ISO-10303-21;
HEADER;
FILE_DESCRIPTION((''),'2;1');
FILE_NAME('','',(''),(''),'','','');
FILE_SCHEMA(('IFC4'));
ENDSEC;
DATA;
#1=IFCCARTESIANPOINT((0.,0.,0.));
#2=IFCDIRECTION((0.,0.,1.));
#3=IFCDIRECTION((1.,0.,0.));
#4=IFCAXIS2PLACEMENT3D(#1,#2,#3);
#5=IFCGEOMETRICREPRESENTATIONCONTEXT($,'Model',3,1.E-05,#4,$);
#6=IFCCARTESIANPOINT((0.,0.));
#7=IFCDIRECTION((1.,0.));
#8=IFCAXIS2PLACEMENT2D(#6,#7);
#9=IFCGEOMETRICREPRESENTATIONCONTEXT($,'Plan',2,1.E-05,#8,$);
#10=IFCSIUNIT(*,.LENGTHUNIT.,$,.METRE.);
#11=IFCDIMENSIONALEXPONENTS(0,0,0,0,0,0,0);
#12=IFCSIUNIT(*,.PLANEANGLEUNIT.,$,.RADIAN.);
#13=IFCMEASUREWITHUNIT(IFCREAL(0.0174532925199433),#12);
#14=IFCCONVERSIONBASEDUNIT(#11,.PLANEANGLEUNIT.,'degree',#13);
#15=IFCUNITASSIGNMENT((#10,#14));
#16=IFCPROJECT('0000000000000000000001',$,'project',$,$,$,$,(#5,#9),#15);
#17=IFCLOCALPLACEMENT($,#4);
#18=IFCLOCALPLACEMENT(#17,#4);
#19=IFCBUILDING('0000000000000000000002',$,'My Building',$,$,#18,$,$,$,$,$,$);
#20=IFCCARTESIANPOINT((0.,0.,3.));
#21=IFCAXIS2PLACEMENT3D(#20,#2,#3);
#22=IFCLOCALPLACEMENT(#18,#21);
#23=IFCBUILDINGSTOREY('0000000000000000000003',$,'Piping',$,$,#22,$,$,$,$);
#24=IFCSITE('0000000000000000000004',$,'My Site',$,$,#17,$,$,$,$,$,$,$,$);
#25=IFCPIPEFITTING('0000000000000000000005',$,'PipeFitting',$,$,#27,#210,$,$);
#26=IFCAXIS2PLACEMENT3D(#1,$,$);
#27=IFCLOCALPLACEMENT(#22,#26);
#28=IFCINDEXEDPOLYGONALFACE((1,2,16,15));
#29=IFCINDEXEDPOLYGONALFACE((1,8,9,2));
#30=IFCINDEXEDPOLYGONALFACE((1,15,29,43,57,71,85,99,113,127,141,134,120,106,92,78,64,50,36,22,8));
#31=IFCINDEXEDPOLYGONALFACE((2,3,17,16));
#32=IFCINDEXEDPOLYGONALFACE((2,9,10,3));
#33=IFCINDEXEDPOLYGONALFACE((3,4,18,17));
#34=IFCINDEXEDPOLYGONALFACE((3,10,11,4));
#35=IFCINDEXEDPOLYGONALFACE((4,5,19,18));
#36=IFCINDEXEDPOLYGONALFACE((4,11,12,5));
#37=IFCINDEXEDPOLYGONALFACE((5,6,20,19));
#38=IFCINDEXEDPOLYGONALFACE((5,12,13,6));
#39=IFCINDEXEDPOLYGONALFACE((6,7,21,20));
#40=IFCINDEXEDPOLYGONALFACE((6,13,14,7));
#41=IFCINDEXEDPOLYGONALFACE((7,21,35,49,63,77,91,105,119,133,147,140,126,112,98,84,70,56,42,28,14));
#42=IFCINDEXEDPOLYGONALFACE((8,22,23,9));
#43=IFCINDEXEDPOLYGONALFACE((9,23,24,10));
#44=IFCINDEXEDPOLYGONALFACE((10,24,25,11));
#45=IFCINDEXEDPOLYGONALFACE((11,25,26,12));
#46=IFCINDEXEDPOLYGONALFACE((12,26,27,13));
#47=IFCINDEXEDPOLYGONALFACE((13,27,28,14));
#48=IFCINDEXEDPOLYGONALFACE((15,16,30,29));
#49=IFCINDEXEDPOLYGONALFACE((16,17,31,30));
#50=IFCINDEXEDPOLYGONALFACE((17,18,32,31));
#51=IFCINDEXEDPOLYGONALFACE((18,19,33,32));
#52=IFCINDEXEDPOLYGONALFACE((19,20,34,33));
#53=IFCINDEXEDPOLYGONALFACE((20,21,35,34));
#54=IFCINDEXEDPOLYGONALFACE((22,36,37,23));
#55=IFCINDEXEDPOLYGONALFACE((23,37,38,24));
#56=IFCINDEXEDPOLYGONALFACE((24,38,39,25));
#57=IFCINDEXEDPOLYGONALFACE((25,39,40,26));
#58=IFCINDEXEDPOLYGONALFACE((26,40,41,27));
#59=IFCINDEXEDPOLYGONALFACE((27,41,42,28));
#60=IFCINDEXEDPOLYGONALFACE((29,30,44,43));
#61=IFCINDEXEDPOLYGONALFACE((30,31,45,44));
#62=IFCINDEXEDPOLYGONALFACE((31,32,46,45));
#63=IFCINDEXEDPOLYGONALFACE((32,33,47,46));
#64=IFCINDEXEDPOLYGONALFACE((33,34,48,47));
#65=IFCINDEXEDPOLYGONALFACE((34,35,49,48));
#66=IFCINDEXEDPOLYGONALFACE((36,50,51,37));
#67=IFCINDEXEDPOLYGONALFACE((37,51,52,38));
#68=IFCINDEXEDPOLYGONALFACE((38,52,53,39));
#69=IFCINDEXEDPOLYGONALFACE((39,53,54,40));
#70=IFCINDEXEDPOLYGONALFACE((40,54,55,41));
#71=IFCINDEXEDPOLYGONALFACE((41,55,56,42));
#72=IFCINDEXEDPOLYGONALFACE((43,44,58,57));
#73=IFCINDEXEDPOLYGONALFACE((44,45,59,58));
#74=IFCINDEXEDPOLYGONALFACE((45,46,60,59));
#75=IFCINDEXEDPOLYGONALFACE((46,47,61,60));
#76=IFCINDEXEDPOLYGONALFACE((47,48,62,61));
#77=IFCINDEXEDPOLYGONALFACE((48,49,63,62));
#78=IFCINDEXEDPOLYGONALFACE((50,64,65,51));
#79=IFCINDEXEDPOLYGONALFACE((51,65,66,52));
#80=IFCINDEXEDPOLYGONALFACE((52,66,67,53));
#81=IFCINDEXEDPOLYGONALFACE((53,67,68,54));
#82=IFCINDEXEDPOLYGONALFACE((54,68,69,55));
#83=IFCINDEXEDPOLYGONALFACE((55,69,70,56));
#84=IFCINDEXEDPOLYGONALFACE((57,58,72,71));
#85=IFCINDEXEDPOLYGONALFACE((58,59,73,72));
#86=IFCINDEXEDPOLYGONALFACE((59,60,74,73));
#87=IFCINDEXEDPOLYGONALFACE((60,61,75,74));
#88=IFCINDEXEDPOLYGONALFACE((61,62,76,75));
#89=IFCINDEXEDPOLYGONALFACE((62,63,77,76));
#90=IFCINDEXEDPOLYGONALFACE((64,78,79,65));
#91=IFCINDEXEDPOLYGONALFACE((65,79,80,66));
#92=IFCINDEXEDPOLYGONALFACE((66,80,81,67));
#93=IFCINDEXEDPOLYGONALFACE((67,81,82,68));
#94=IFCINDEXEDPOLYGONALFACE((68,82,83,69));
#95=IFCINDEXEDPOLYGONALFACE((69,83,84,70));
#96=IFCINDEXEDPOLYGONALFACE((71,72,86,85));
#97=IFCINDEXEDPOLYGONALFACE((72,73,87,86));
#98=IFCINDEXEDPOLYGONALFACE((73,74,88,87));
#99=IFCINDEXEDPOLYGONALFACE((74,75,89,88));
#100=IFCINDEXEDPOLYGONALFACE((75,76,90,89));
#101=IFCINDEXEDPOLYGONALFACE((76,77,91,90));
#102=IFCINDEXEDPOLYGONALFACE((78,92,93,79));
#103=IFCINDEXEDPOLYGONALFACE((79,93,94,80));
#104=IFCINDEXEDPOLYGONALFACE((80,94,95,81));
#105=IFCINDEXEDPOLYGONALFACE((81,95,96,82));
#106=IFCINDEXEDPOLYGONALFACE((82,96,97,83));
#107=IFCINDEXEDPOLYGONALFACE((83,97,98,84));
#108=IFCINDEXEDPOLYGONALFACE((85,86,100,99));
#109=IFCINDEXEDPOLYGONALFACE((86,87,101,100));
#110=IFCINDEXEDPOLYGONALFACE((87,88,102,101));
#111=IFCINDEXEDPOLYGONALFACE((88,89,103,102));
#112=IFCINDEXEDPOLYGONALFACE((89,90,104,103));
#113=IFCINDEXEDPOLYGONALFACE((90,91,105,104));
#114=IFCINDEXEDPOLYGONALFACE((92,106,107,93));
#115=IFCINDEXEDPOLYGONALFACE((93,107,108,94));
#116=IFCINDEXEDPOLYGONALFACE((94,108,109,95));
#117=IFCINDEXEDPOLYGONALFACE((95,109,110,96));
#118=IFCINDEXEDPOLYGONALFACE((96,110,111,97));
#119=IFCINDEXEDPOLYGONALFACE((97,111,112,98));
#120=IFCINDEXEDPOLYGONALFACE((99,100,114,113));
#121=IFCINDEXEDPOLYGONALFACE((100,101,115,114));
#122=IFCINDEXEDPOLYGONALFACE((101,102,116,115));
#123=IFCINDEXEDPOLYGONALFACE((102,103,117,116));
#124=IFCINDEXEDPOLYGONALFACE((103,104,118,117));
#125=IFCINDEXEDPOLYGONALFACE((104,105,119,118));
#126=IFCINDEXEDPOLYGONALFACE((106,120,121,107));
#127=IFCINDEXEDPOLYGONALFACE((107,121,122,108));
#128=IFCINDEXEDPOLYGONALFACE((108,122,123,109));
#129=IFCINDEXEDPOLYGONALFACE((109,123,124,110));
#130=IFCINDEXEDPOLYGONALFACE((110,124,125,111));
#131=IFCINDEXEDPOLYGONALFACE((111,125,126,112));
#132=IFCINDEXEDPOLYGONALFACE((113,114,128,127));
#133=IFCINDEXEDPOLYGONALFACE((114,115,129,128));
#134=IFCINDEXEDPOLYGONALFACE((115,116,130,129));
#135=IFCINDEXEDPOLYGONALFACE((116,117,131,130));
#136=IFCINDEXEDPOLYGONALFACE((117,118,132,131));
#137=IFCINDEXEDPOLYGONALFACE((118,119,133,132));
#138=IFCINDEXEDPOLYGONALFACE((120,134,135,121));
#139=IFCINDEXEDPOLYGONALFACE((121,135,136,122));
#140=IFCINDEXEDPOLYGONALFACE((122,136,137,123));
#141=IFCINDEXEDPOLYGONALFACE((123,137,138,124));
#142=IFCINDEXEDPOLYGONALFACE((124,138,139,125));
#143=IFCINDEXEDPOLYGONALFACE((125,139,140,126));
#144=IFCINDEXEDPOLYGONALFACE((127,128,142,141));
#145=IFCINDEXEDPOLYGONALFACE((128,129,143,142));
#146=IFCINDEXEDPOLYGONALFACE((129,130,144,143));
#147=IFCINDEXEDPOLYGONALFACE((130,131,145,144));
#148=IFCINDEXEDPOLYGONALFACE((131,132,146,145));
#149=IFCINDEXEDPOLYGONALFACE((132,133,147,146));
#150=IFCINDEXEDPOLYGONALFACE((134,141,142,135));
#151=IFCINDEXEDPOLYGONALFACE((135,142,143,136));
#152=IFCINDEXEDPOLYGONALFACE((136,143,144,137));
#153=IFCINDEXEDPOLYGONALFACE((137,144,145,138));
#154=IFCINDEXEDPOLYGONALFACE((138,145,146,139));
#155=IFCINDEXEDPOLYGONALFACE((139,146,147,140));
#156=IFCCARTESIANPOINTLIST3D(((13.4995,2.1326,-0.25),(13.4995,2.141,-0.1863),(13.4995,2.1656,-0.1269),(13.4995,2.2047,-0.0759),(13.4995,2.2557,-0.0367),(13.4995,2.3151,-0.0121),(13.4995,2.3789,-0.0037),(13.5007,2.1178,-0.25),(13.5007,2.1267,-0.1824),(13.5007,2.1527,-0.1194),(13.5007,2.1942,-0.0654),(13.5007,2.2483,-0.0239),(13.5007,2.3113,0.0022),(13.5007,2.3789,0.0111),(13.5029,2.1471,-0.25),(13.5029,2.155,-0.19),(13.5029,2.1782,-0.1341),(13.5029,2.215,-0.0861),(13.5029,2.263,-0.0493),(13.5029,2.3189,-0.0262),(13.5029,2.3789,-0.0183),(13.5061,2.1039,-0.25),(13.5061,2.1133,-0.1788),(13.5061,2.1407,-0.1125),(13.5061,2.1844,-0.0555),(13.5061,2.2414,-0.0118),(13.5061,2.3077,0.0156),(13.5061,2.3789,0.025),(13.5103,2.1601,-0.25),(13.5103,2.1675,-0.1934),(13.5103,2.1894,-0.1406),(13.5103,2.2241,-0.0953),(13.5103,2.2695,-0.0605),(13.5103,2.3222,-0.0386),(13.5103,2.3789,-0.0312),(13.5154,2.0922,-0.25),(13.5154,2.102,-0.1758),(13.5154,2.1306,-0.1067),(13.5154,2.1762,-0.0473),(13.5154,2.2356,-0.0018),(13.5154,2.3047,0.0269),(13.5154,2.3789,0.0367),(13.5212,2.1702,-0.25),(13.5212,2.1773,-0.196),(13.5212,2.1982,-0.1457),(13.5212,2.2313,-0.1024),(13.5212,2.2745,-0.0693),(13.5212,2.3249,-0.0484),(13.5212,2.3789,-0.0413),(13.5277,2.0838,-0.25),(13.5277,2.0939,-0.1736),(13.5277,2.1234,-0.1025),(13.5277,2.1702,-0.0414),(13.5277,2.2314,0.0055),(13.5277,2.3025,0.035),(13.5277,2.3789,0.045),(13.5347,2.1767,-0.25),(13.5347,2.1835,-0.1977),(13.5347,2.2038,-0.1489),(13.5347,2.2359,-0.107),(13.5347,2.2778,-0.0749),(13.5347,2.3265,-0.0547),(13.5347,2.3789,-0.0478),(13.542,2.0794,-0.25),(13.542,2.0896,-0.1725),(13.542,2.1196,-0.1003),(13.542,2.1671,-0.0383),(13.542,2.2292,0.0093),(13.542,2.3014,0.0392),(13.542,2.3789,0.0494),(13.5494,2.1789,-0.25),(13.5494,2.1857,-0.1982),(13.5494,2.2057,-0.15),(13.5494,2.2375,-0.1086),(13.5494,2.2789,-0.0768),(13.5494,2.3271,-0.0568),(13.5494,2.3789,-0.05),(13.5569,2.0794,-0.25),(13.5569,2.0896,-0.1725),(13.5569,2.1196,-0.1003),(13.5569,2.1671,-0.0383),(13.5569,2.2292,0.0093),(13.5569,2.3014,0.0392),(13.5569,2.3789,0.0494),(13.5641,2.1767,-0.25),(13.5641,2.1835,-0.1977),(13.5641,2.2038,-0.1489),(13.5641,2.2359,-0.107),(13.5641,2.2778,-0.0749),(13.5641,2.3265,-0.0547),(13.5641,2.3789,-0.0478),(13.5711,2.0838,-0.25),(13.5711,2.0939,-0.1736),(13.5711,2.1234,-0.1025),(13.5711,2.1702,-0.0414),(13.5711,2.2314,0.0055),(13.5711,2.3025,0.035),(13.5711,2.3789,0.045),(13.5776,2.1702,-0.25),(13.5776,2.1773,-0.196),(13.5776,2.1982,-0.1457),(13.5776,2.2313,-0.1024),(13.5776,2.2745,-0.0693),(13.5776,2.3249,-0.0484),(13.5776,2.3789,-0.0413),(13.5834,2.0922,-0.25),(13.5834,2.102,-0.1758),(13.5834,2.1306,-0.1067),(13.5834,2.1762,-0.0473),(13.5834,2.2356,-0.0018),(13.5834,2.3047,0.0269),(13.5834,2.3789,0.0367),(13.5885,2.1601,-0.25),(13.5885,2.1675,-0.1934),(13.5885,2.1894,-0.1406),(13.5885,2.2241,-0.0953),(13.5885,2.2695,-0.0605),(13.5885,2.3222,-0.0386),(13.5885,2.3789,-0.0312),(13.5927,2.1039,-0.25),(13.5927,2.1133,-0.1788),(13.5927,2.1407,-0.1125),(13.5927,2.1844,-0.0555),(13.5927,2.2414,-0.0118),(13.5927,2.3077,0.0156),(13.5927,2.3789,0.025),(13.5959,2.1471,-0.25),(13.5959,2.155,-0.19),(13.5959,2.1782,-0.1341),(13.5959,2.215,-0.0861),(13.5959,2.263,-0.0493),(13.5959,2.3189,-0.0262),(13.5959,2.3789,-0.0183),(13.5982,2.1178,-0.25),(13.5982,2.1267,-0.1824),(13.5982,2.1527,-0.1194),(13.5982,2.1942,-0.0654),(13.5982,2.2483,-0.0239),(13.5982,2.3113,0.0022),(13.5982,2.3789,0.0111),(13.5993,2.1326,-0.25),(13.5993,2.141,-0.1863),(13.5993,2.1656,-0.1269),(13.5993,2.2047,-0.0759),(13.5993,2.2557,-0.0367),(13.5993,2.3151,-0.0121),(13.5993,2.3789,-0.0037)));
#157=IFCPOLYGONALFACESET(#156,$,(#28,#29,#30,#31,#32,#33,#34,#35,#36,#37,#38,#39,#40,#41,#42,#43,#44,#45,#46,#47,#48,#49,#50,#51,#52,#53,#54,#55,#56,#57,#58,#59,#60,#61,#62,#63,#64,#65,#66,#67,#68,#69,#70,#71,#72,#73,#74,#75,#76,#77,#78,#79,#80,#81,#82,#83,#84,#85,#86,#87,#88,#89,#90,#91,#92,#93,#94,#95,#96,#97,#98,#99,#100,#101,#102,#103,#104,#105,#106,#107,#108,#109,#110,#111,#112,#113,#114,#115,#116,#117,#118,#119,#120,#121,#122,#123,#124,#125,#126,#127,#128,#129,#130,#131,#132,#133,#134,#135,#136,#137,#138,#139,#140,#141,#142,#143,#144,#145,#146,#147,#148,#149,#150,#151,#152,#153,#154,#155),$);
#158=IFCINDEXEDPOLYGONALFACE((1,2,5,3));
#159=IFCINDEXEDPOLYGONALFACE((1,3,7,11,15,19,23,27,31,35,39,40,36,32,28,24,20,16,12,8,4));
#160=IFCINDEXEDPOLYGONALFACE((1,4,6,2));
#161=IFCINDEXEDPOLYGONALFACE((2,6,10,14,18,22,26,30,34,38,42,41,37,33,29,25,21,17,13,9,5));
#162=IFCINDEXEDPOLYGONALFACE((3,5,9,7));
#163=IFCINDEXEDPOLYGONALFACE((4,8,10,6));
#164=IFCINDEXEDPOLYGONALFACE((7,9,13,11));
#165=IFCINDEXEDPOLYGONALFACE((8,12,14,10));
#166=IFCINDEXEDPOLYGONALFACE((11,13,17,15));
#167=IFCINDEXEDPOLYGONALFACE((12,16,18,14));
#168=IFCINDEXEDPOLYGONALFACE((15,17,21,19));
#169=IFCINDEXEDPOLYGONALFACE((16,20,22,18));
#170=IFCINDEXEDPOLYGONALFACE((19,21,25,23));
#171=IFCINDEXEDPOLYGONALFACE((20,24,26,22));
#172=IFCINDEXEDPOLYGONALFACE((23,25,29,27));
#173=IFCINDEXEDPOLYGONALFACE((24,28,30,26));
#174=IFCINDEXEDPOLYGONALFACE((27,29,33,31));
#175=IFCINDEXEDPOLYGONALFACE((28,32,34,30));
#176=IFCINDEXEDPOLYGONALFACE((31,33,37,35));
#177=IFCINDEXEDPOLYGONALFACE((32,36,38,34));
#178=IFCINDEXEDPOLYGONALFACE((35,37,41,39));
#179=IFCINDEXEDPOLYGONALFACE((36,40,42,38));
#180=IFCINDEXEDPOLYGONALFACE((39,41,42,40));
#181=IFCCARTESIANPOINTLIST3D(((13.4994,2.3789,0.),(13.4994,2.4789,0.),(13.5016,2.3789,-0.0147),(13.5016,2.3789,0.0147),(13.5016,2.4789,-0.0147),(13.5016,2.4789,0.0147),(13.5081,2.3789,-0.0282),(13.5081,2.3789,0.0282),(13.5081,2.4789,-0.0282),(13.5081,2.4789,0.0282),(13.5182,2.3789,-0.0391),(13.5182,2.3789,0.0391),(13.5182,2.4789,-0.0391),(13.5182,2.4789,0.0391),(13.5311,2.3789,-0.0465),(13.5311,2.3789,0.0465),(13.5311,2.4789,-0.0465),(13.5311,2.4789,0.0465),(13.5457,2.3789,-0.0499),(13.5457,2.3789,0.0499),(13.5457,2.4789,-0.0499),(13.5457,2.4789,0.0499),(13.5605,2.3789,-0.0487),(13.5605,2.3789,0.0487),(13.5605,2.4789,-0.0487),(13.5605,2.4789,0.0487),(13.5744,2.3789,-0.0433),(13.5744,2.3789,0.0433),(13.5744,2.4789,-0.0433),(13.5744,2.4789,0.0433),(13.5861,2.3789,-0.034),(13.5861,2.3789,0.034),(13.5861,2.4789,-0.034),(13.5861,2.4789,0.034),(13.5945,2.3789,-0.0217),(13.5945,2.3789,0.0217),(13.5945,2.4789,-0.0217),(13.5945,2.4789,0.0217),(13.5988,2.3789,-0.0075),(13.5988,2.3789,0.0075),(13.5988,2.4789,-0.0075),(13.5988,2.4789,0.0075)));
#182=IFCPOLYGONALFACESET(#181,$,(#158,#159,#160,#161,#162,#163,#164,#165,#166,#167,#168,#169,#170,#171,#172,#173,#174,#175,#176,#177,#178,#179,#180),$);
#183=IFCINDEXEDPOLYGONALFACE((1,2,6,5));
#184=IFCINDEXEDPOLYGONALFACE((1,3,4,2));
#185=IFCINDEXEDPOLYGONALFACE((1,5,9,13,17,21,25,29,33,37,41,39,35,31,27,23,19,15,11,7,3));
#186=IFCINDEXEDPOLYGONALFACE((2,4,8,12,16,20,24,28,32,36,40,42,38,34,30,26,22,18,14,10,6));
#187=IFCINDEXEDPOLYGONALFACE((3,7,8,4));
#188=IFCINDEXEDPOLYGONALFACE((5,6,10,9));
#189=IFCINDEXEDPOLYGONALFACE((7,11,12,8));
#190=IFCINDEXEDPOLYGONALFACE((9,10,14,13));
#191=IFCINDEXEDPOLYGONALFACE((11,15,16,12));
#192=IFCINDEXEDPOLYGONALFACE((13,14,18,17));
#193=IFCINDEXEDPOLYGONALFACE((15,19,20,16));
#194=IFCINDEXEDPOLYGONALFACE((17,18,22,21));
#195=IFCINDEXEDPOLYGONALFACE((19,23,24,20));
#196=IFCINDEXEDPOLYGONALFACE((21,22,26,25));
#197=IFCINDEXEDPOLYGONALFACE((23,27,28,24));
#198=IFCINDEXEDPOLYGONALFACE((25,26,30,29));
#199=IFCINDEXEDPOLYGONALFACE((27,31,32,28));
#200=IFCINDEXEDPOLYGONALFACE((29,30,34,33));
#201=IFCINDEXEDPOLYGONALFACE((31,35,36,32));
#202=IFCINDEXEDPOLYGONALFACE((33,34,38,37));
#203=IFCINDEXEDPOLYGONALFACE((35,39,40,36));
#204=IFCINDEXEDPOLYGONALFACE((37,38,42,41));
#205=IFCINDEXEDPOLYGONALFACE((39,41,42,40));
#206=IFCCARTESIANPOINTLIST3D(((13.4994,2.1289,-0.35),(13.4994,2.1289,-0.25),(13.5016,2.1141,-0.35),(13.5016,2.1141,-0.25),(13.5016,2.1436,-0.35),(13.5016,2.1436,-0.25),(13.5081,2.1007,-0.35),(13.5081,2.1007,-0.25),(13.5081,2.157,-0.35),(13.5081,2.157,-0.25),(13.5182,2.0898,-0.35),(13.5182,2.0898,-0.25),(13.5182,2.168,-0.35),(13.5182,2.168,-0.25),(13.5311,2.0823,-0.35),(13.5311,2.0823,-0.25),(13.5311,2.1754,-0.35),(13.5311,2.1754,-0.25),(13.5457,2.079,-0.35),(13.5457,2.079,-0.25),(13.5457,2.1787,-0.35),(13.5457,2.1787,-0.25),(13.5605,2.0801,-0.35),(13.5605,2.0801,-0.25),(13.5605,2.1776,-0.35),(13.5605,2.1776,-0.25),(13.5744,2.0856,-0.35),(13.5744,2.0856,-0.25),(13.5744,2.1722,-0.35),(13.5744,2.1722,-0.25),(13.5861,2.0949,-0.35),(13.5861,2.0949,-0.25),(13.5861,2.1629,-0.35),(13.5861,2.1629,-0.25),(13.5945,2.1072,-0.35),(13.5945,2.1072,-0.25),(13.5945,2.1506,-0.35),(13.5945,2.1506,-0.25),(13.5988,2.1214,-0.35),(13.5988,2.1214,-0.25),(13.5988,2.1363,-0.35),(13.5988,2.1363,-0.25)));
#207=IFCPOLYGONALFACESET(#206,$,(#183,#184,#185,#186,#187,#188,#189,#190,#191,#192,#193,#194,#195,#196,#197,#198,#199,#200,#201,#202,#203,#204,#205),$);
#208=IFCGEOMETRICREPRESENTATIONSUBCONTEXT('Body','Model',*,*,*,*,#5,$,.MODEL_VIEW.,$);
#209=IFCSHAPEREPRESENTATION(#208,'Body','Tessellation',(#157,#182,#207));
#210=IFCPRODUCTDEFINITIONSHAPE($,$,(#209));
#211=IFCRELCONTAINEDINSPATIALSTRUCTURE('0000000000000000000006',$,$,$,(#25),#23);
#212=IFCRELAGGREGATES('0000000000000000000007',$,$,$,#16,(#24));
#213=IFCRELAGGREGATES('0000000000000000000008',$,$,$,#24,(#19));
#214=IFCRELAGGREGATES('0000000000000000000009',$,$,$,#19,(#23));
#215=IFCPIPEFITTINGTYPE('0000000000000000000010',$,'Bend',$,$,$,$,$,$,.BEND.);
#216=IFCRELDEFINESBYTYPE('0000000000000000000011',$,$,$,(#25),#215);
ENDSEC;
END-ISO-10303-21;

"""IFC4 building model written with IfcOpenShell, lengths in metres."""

from ifc_helpers import new_model, entity, si_unit, converted_unit, frame, origin_with_axes, origin_2d_with_axis, place, context, subcontext, project, spatial, circle, extrude, source, transform, mapped, type_object, type_shapes, element, save


model = new_model("IFC4")

# Units and contexts
model_context = context("Model", 3, precision=1e-05, world=origin_with_axes())
plan_context = context("Plan", 2, precision=1e-05, world=origin_2d_with_axis())
body_context = subcontext(model_context, "Body", "Model", "MODEL_VIEW")
ifc_project = project(units=[si_unit("LENGTHUNIT", "METRE"), converted_unit("PLANEANGLEUNIT", "degree", entity("IfcReal", 0.0174532925199433), si_unit("PLANEANGLEUNIT", "RADIAN"), dimensions=[0, 0, 0, 0, 0, 0, 0])], contexts=[model_context, plan_context])

# Site, building, storey
site_placement = place(None, origin_with_axes())
site = spatial("IfcSite", under=ifc_project, at=site_placement, Name="My Site")
building_placement = place(site_placement, origin_with_axes())
building = spatial("IfcBuilding", under=site, at=building_placement, Name="My Building")
storey_placement = place(building_placement, frame((0.0, 0.0, 3.0), z_axis=(0.0, 0.0, 1.0), x_axis=(1.0, 0.0, 0.0)))
storey = spatial("IfcBuildingStorey", under=building, at=storey_placement, Name="Piping")

# Pipe fitting
pipe_fitting_type = type_object("IfcPipeFittingType", Name="Bend", PredefinedType="BEND")
shared_shape = source(origin_with_axes(), body_context, "Body", "SolidModel", [
    entity("IfcSweptDiskSolid", entity("IfcIndexedPolyCurve", entity("IfcCartesianPointList3D", [[0.0, 0.0, -0.1], [0.0, -0.0732, -0.2768], [0.0, -0.25, -0.35]]), [entity("IfcArcIndex", [1, 2, 3])]), 0.05),
    extrude(circle(Radius=0.05), origin_with_axes(), (0.0, 0.0, -1.0), 0.1),
    extrude(circle(Radius=0.05), frame((0.0, -0.25, -0.35), z_axis=(0.0, -1.0, 0.0), x_axis=(1.0, 0.0, 0.0)), (0.0, 0.0, 1.0), 0.1),
])
type_shapes(pipe_fitting_type, [shared_shape])
for number, where, z_axis, x_axis, name in (
    (1, (13.5494, 2.4789, 0.0), (0.0, 1.0, 0.0), (-1.0, 0.0, 0.0), "PipeFitting"),
):
    element("IfcPipeFitting", number, at=place(storey_placement, frame(where, z_axis=z_axis, x_axis=x_axis)), inside=storey, type_object=pipe_fitting_type, Name=name, context=body_context, shape_type="MappedRepresentation", body=[
        mapped(shared_shape, transform((0.0, 0.0, 0.0), x_axis=(1.0, 0.0, 0.0), y_axis=(0.0, 1.0, 0.0), z_axis=(0.0, 0.0, 1.0), scale=1.0)),
    ])

save(model, "model.ifc")
